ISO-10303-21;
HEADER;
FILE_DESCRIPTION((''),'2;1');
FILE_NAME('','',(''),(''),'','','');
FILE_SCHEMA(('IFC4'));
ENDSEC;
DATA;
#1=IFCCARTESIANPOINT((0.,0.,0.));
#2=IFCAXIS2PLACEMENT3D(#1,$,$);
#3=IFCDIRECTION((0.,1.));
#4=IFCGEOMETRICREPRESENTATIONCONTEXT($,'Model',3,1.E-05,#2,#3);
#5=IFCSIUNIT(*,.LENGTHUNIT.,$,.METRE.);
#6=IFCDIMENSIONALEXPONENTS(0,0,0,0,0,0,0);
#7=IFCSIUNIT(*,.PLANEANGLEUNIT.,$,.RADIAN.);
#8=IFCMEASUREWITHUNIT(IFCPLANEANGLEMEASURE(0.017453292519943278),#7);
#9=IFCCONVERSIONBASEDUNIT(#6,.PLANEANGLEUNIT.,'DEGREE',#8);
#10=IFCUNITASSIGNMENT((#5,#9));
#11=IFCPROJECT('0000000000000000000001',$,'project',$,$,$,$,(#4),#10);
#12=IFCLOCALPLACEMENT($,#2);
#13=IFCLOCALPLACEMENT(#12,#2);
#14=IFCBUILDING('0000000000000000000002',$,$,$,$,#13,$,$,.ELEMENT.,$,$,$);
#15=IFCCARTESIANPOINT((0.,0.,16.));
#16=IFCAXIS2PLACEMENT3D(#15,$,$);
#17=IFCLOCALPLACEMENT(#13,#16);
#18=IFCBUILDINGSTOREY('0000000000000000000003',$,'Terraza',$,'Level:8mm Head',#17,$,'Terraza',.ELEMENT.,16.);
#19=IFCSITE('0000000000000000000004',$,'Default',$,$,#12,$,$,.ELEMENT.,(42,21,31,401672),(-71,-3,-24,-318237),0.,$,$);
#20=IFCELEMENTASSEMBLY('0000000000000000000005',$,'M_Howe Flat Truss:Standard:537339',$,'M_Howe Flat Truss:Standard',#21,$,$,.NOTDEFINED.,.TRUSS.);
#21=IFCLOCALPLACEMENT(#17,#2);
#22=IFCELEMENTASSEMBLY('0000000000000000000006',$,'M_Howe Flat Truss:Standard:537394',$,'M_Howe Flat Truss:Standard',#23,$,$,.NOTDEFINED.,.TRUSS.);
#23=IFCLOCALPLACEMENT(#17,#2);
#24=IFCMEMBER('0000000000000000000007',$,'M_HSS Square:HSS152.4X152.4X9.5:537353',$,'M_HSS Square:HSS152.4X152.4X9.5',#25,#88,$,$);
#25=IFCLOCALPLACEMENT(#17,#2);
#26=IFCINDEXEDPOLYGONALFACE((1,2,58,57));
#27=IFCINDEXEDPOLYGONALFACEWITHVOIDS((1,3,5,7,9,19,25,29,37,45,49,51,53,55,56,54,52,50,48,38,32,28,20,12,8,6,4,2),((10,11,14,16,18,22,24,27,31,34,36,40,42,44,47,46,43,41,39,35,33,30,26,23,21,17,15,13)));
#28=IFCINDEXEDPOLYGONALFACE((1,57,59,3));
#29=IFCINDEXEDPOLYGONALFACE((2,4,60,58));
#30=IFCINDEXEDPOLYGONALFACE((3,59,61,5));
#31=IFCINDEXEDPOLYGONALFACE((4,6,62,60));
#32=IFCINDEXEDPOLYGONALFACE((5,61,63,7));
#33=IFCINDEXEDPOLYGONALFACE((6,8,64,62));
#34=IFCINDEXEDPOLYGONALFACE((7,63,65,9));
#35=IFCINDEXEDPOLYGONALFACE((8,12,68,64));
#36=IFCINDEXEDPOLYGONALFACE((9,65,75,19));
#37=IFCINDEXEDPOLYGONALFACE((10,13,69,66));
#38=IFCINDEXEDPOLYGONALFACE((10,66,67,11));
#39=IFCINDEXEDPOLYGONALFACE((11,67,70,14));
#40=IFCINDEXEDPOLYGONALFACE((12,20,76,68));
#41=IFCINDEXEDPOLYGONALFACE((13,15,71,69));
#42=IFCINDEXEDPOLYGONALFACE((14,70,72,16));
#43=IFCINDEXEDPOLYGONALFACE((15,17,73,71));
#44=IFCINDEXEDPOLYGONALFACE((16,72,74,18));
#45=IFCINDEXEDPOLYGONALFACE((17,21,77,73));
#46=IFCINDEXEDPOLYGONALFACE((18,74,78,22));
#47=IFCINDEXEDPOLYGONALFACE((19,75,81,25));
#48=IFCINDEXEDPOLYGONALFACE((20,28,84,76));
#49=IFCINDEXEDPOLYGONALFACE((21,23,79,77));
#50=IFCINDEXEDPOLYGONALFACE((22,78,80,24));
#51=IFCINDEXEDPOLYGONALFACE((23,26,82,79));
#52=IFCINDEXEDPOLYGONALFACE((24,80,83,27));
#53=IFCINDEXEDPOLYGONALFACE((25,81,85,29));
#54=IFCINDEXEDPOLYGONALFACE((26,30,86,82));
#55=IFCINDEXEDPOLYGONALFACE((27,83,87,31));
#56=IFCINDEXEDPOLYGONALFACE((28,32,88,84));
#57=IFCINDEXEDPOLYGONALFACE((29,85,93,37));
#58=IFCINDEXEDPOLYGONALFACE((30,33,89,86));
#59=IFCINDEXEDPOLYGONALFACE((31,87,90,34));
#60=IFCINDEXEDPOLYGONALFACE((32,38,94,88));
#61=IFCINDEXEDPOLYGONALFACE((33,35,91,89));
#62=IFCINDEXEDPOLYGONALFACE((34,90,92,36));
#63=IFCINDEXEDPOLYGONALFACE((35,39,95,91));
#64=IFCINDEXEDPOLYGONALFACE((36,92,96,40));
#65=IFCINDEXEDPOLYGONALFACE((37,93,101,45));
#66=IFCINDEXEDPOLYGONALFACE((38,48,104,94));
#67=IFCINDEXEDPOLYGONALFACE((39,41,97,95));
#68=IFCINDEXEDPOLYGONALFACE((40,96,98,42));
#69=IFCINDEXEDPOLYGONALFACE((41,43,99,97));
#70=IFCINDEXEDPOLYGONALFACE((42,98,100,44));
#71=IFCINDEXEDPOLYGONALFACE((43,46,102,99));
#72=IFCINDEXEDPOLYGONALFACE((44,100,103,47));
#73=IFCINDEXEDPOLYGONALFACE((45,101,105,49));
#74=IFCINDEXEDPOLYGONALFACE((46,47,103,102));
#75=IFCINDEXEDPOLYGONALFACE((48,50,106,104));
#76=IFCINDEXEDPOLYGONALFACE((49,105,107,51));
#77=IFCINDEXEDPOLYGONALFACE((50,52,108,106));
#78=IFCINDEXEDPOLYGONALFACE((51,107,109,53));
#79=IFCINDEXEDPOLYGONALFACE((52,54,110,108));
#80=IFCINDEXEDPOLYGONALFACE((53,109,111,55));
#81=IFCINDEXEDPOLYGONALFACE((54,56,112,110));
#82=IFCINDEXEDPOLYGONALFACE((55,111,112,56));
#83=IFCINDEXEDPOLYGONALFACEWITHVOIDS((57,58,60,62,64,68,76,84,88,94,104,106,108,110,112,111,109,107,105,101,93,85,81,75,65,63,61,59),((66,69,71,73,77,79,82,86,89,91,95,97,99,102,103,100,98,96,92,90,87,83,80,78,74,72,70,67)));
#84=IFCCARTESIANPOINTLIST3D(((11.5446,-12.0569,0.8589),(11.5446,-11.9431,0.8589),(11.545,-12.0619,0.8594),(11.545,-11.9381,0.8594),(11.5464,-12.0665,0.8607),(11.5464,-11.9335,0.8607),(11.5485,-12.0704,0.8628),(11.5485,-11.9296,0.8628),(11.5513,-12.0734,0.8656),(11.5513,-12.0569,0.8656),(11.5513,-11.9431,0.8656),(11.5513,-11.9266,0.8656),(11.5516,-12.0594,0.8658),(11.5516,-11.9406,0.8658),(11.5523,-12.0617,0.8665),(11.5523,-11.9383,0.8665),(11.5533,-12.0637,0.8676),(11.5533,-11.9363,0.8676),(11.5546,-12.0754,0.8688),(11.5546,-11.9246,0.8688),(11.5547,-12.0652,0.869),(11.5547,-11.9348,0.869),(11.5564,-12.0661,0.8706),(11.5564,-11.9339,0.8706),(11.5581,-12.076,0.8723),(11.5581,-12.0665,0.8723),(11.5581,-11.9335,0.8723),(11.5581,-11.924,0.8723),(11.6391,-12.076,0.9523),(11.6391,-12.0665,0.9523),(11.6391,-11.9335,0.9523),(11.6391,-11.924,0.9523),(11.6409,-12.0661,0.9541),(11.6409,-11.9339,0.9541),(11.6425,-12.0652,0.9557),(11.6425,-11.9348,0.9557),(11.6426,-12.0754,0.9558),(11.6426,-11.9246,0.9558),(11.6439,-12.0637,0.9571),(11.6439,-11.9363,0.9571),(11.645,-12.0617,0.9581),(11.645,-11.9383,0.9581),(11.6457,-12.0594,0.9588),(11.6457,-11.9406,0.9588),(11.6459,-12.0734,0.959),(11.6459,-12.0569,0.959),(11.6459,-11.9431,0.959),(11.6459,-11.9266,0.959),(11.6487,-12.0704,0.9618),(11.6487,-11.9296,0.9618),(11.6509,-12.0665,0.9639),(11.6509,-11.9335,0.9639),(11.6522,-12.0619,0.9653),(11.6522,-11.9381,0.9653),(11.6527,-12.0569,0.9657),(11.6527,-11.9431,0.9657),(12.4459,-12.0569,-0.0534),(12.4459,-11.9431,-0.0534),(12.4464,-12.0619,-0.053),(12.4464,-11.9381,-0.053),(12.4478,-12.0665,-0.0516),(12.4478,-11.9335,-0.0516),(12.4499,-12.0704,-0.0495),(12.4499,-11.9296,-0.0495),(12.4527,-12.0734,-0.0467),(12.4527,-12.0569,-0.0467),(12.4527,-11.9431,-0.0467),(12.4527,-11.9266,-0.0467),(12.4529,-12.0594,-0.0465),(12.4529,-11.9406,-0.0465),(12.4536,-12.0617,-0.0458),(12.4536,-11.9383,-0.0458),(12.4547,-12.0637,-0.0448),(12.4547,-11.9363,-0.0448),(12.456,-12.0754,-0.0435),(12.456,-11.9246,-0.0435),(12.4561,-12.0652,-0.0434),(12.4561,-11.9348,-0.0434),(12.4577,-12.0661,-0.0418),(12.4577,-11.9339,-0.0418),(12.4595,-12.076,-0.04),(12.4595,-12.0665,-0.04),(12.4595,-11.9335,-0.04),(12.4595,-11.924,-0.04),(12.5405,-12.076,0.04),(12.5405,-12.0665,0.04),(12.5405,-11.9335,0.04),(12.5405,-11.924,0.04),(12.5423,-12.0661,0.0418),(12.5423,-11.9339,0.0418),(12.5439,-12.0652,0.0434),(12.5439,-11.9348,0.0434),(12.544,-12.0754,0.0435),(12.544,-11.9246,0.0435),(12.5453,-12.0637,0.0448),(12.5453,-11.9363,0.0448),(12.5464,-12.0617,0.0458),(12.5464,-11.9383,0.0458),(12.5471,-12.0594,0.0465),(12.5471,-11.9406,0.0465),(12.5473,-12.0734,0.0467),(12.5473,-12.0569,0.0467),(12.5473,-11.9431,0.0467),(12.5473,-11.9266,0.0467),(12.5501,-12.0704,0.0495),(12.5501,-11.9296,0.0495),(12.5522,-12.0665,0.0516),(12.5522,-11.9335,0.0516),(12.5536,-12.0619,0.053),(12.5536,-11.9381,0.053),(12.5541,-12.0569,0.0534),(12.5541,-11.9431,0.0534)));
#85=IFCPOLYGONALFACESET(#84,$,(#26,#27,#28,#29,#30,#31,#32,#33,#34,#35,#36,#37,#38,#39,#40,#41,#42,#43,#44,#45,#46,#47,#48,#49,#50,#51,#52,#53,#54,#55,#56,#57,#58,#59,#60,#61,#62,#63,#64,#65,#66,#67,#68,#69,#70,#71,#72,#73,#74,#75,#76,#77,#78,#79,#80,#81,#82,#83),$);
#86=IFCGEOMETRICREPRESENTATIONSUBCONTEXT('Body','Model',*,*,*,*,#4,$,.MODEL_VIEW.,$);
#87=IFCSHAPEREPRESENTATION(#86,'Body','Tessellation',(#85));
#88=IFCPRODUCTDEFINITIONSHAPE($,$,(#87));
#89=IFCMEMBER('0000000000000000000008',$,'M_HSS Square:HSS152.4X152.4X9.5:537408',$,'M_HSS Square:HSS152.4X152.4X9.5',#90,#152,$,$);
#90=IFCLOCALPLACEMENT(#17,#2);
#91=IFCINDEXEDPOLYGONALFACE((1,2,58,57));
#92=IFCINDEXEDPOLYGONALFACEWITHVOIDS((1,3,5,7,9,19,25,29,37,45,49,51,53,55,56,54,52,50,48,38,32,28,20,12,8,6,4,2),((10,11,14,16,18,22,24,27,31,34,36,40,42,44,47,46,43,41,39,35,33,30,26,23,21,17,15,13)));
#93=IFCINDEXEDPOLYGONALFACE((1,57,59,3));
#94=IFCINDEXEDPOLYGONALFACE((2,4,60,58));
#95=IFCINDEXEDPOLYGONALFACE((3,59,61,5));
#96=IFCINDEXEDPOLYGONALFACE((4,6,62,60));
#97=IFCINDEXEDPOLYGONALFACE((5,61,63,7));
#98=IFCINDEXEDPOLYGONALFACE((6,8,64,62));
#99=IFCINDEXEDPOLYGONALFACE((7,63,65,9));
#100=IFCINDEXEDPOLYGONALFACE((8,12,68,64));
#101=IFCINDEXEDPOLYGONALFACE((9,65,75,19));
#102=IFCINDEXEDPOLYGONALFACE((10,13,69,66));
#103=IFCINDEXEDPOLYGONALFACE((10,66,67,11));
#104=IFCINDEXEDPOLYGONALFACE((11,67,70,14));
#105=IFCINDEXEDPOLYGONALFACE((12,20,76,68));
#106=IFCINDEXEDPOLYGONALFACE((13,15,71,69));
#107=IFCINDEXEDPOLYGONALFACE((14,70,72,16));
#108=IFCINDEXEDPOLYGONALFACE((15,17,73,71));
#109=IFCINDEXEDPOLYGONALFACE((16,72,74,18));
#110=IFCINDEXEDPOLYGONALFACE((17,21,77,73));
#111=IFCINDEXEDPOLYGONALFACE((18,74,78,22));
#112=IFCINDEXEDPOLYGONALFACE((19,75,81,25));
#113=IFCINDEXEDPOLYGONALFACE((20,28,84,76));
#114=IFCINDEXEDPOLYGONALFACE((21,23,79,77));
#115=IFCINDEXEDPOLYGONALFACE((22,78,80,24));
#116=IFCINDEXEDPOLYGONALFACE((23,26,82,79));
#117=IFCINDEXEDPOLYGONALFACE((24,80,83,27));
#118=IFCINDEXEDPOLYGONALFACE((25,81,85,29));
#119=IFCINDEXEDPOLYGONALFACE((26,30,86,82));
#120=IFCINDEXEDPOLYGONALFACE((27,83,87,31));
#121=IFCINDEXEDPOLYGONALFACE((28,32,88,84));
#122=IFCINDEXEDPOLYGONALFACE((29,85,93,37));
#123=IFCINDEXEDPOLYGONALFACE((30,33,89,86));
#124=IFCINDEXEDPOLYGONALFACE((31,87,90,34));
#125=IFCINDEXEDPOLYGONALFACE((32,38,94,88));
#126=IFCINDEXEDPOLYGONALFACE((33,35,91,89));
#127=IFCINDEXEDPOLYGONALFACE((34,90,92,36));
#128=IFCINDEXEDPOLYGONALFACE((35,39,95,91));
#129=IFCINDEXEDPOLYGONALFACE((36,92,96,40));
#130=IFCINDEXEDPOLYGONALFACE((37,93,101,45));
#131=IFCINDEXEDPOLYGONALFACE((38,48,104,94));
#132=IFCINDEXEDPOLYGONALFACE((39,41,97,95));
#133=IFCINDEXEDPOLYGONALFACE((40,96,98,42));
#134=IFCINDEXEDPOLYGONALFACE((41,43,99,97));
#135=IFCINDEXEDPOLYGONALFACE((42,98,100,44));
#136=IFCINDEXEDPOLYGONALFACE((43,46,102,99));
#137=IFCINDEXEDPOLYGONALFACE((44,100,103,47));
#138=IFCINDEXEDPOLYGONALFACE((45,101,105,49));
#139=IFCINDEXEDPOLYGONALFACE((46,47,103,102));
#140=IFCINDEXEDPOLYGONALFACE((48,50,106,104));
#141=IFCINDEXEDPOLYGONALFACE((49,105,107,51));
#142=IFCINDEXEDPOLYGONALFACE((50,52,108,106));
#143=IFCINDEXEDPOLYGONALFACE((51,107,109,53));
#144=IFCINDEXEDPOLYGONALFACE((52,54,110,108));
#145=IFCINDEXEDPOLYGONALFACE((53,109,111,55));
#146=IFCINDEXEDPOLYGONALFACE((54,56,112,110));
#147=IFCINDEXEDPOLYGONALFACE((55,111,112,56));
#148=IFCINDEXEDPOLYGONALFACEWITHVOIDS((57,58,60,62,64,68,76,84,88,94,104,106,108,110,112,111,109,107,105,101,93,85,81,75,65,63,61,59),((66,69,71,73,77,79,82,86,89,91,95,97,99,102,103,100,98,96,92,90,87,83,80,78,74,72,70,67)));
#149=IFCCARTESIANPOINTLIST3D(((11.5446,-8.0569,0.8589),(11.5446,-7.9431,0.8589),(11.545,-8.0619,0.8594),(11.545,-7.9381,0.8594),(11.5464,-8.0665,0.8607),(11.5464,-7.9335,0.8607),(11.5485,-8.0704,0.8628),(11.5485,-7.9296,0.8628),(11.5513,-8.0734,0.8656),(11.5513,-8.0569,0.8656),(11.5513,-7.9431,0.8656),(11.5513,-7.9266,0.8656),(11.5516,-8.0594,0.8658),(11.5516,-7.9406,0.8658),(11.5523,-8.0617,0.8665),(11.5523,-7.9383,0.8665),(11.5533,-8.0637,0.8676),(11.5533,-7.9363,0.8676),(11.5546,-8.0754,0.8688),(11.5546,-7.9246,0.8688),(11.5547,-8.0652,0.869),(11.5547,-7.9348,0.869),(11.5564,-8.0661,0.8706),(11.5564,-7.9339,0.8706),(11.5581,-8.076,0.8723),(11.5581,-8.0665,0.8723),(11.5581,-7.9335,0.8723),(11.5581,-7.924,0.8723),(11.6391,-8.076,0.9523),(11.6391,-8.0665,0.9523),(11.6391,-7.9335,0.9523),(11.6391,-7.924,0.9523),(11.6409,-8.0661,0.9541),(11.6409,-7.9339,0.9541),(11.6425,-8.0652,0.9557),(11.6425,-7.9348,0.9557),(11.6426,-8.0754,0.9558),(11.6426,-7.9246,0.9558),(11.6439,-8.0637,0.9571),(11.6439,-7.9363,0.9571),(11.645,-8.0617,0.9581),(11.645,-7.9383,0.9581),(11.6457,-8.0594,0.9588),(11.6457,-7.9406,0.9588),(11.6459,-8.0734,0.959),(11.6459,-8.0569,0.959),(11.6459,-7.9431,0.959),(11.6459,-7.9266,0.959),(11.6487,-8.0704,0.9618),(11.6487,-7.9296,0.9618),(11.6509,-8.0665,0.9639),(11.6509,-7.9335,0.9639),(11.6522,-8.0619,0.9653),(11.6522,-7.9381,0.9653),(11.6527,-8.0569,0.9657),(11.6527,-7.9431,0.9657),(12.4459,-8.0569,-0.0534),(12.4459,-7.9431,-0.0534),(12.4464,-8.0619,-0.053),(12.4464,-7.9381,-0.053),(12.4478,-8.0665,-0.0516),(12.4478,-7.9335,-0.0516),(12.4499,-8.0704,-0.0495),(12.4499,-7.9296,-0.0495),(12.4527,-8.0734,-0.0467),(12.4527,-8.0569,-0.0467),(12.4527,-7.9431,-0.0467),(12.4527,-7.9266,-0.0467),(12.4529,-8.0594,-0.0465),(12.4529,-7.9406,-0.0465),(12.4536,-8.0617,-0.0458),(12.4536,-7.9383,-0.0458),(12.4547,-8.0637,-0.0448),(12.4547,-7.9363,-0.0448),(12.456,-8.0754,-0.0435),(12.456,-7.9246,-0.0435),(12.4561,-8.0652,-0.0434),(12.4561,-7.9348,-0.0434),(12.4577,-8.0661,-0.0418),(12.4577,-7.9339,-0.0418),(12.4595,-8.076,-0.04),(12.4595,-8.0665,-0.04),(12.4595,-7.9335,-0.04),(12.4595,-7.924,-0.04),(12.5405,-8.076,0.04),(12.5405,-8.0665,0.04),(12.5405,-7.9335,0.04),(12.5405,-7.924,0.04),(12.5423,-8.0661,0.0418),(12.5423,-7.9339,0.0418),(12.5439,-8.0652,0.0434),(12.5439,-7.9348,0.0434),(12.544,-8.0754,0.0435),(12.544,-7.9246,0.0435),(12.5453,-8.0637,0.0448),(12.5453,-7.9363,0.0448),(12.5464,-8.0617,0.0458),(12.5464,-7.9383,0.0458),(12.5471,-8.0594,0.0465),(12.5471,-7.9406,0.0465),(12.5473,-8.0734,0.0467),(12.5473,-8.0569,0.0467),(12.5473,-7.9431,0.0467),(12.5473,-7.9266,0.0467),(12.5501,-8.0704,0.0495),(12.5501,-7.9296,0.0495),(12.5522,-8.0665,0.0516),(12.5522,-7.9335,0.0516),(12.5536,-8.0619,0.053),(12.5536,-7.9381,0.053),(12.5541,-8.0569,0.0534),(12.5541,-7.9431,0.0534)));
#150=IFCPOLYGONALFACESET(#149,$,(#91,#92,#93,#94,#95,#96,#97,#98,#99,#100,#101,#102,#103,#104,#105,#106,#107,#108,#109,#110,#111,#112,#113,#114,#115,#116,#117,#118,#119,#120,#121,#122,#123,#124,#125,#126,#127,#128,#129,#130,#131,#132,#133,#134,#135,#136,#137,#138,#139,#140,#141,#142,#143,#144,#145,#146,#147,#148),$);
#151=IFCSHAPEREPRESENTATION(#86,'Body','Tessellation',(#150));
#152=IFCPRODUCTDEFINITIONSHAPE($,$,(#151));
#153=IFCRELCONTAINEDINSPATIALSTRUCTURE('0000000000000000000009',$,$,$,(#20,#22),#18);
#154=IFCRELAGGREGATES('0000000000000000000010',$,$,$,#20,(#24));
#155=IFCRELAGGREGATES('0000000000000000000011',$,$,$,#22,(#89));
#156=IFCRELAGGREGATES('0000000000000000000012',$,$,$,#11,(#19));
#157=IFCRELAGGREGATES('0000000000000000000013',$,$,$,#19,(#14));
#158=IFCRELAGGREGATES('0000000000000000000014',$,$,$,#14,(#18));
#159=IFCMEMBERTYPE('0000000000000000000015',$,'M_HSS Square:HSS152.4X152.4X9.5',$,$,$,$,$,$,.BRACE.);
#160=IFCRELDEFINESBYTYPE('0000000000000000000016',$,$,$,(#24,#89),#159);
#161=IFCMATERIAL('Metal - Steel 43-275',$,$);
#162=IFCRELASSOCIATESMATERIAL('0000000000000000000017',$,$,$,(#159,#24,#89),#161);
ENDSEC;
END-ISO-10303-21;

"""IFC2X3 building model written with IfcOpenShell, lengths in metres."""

from ifc_helpers import new_model, entity, si_unit, converted_unit, direction, frame, frame_2d, origin, place, context, subcontext, project, spatial, polyline, circle_curve, parameter, trimmed, segment, composite_curve, outline, extrude, source, transform, mapped, material, type_object, type_shapes, element, aggregate, save


model = new_model("IFC2X3")

# Units and contexts
model_context = context("Model", 3, precision=1e-05, world=origin(), true_north=direction((0.0, 1.0)))
body_context = subcontext(model_context, "Body", "Model", "MODEL_VIEW")
ifc_project = project(units=[si_unit("LENGTHUNIT", "METRE"), converted_unit("PLANEANGLEUNIT", "DEGREE", entity("IfcPlaneAngleMeasure", 0.017453292519943278), si_unit("PLANEANGLEUNIT", "RADIAN"), dimensions=[0, 0, 0, 0, 0, 0, 0])], contexts=[model_context])

# Site, building, storey
site_placement = place(None, origin())
site = spatial("IfcSite", under=ifc_project, at=site_placement, Name="Default", CompositionType="ELEMENT", RefLatitude=(42, 21, 31, 401672), RefLongitude=(-71, -3, -24, -318237), RefElevation=0.0)
building_placement = place(site_placement, origin())
building = spatial("IfcBuilding", under=site, at=building_placement, CompositionType="ELEMENT")
storey_placement = place(building_placement, frame((0.0, 0.0, 16.0)))
storey = spatial("IfcBuildingStorey", under=building, at=storey_placement, Name="Terraza", ObjectType="Level:8mm Head", LongName="Terraza", CompositionType="ELEMENT", Elevation=16.0)

# Element assemblies
ifc_material = material(Name="Metal - Steel 43-275")
assembly_1_placement = place(storey_placement, origin())
assembly_1 = element("IfcElementAssembly", 1, at=assembly_1_placement, inside=storey, Name="M_Howe Flat Truss:Standard:537339", ObjectType="M_Howe Flat Truss:Standard", AssemblyPlace="NOTDEFINED", PredefinedType="TRUSS")
assembly_2_placement = place(storey_placement, origin())
assembly_2 = element("IfcElementAssembly", 2, at=assembly_2_placement, inside=storey, Name="M_Howe Flat Truss:Standard:537394", ObjectType="M_Howe Flat Truss:Standard", AssemblyPlace="NOTDEFINED", PredefinedType="TRUSS")

# Members
member_type_1 = type_object("IfcMemberType", Name="M_HSS Square:HSS152.4X152.4X9.5", PredefinedType="BRACE", material=ifc_material)
shared_shape_1 = source(origin(), body_context, "Body", "SweptSolid", [
    extrude(outline(composite_curve([segment(polyline([(-0.0569, -0.076), (0.0569, -0.076)]), True, "CONTINUOUS"), segment(trimmed(circle_curve(frame_2d((0.0569, -0.0569), x_axis=(0.0, 1.0)), 0.0191), [parameter(180.0)], [parameter(270.0)], True, "PARAMETER"), True, "CONTINUOUS"), segment(polyline([(0.076, -0.0569), (0.076, 0.0569)]), True, "CONTINUOUS"), segment(trimmed(circle_curve(frame_2d((0.0569, 0.0569), x_axis=(0.0, 1.0)), 0.0191), [parameter(270.0)], [parameter(0.0)], True, "PARAMETER"), True, "CONTINUOUS"), segment(polyline([(0.0569, 0.076), (-0.0569, 0.076)]), True, "CONTINUOUS"), segment(trimmed(circle_curve(frame_2d((-0.0569, 0.0569), x_axis=(0.0, 1.0)), 0.0191), [parameter(0.0)], [parameter(90.0)], True, "PARAMETER"), True, "CONTINUOUS"), segment(polyline([(-0.076, 0.0569), (-0.076, -0.0569)]), True, "CONTINUOUS"), segment(trimmed(circle_curve(frame_2d((-0.0569, -0.0569), x_axis=(0.0, 1.0)), 0.0191), [parameter(90.0)], [parameter(180.0)], True, "PARAMETER"), True, "CONTINUOUS")], self_intersect=False), holes=[composite_curve([segment(trimmed(circle_curve(frame_2d((-0.0569, 0.0569), x_axis=(0.0, 1.0)), 0.0095), [parameter(360.0)], [parameter(90.0)], True, "PARAMETER"), False, "CONTINUOUS"), segment(polyline([(-0.0569, 0.0665), (0.0569, 0.0665)]), True, "CONTINUOUS"), segment(trimmed(circle_curve(frame_2d((0.0569, 0.0569), x_axis=(0.0, 1.0)), 0.0095), [parameter(270.0)], [parameter(360.0)], True, "PARAMETER"), False, "CONTINUOUS"), segment(polyline([(0.0665, 0.0569), (0.0665, -0.0569)]), True, "CONTINUOUS"), segment(trimmed(circle_curve(frame_2d((0.0569, -0.0569), x_axis=(0.0, 1.0)), 0.0095), [parameter(180.0)], [parameter(270.0)], True, "PARAMETER"), False, "CONTINUOUS"), segment(polyline([(0.0569, -0.0665), (-0.0569, -0.0665)]), True, "CONTINUOUS"), segment(trimmed(circle_curve(frame_2d((-0.0569, -0.0569), x_axis=(0.0, 1.0)), 0.0095), [parameter(90.0)], [parameter(180.0)], True, "PARAMETER"), False, "CONTINUOUS"), segment(polyline([(-0.0665, -0.0569), (-0.0665, 0.0569)]), True, "CONTINUOUS")], self_intersect=False)]), frame((-0.5357, 0.0, 0.0), z_axis=(1.0, 0.0, 0.0), x_axis=(0.0, 0.0, -1.0)), (0.0, 0.0, 1.0), 1.2825),
])
type_shapes(member_type_1, [shared_shape_1])
member_1_placement = place(assembly_1_placement, frame((11.9751, -12.0, 0.5312), z_axis=(-0.711368, 0.0, -0.702819), x_axis=(0.702819, 0.0, -0.711368)))
member_1 = element("IfcMember", 3, at=member_1_placement, type_object=member_type_1, material=ifc_material, Name="M_HSS Square:HSS152.4X152.4X9.5:537353", ObjectType="M_HSS Square:HSS152.4X152.4X9.5", context=body_context, shape_type="MappedRepresentation", body=[
    mapped(shared_shape_1, transform((0.0, 0.0, 0.0), scale=1.0)),
])
aggregate(assembly_1, [member_1])
member_2_placement = place(assembly_2_placement, frame((11.9751, -8.0, 0.5312), z_axis=(-0.711368, 0.0, -0.702819), x_axis=(0.702819, 0.0, -0.711368)))
member_2 = element("IfcMember", 4, at=member_2_placement, type_object=member_type_1, material=ifc_material, Name="M_HSS Square:HSS152.4X152.4X9.5:537408", ObjectType="M_HSS Square:HSS152.4X152.4X9.5", context=body_context, shape_type="MappedRepresentation", body=[
    mapped(shared_shape_1, transform((0.0, 0.0, 0.0), scale=1.0)),
])
aggregate(assembly_2, [member_2])

save(model, "model.ifc")
